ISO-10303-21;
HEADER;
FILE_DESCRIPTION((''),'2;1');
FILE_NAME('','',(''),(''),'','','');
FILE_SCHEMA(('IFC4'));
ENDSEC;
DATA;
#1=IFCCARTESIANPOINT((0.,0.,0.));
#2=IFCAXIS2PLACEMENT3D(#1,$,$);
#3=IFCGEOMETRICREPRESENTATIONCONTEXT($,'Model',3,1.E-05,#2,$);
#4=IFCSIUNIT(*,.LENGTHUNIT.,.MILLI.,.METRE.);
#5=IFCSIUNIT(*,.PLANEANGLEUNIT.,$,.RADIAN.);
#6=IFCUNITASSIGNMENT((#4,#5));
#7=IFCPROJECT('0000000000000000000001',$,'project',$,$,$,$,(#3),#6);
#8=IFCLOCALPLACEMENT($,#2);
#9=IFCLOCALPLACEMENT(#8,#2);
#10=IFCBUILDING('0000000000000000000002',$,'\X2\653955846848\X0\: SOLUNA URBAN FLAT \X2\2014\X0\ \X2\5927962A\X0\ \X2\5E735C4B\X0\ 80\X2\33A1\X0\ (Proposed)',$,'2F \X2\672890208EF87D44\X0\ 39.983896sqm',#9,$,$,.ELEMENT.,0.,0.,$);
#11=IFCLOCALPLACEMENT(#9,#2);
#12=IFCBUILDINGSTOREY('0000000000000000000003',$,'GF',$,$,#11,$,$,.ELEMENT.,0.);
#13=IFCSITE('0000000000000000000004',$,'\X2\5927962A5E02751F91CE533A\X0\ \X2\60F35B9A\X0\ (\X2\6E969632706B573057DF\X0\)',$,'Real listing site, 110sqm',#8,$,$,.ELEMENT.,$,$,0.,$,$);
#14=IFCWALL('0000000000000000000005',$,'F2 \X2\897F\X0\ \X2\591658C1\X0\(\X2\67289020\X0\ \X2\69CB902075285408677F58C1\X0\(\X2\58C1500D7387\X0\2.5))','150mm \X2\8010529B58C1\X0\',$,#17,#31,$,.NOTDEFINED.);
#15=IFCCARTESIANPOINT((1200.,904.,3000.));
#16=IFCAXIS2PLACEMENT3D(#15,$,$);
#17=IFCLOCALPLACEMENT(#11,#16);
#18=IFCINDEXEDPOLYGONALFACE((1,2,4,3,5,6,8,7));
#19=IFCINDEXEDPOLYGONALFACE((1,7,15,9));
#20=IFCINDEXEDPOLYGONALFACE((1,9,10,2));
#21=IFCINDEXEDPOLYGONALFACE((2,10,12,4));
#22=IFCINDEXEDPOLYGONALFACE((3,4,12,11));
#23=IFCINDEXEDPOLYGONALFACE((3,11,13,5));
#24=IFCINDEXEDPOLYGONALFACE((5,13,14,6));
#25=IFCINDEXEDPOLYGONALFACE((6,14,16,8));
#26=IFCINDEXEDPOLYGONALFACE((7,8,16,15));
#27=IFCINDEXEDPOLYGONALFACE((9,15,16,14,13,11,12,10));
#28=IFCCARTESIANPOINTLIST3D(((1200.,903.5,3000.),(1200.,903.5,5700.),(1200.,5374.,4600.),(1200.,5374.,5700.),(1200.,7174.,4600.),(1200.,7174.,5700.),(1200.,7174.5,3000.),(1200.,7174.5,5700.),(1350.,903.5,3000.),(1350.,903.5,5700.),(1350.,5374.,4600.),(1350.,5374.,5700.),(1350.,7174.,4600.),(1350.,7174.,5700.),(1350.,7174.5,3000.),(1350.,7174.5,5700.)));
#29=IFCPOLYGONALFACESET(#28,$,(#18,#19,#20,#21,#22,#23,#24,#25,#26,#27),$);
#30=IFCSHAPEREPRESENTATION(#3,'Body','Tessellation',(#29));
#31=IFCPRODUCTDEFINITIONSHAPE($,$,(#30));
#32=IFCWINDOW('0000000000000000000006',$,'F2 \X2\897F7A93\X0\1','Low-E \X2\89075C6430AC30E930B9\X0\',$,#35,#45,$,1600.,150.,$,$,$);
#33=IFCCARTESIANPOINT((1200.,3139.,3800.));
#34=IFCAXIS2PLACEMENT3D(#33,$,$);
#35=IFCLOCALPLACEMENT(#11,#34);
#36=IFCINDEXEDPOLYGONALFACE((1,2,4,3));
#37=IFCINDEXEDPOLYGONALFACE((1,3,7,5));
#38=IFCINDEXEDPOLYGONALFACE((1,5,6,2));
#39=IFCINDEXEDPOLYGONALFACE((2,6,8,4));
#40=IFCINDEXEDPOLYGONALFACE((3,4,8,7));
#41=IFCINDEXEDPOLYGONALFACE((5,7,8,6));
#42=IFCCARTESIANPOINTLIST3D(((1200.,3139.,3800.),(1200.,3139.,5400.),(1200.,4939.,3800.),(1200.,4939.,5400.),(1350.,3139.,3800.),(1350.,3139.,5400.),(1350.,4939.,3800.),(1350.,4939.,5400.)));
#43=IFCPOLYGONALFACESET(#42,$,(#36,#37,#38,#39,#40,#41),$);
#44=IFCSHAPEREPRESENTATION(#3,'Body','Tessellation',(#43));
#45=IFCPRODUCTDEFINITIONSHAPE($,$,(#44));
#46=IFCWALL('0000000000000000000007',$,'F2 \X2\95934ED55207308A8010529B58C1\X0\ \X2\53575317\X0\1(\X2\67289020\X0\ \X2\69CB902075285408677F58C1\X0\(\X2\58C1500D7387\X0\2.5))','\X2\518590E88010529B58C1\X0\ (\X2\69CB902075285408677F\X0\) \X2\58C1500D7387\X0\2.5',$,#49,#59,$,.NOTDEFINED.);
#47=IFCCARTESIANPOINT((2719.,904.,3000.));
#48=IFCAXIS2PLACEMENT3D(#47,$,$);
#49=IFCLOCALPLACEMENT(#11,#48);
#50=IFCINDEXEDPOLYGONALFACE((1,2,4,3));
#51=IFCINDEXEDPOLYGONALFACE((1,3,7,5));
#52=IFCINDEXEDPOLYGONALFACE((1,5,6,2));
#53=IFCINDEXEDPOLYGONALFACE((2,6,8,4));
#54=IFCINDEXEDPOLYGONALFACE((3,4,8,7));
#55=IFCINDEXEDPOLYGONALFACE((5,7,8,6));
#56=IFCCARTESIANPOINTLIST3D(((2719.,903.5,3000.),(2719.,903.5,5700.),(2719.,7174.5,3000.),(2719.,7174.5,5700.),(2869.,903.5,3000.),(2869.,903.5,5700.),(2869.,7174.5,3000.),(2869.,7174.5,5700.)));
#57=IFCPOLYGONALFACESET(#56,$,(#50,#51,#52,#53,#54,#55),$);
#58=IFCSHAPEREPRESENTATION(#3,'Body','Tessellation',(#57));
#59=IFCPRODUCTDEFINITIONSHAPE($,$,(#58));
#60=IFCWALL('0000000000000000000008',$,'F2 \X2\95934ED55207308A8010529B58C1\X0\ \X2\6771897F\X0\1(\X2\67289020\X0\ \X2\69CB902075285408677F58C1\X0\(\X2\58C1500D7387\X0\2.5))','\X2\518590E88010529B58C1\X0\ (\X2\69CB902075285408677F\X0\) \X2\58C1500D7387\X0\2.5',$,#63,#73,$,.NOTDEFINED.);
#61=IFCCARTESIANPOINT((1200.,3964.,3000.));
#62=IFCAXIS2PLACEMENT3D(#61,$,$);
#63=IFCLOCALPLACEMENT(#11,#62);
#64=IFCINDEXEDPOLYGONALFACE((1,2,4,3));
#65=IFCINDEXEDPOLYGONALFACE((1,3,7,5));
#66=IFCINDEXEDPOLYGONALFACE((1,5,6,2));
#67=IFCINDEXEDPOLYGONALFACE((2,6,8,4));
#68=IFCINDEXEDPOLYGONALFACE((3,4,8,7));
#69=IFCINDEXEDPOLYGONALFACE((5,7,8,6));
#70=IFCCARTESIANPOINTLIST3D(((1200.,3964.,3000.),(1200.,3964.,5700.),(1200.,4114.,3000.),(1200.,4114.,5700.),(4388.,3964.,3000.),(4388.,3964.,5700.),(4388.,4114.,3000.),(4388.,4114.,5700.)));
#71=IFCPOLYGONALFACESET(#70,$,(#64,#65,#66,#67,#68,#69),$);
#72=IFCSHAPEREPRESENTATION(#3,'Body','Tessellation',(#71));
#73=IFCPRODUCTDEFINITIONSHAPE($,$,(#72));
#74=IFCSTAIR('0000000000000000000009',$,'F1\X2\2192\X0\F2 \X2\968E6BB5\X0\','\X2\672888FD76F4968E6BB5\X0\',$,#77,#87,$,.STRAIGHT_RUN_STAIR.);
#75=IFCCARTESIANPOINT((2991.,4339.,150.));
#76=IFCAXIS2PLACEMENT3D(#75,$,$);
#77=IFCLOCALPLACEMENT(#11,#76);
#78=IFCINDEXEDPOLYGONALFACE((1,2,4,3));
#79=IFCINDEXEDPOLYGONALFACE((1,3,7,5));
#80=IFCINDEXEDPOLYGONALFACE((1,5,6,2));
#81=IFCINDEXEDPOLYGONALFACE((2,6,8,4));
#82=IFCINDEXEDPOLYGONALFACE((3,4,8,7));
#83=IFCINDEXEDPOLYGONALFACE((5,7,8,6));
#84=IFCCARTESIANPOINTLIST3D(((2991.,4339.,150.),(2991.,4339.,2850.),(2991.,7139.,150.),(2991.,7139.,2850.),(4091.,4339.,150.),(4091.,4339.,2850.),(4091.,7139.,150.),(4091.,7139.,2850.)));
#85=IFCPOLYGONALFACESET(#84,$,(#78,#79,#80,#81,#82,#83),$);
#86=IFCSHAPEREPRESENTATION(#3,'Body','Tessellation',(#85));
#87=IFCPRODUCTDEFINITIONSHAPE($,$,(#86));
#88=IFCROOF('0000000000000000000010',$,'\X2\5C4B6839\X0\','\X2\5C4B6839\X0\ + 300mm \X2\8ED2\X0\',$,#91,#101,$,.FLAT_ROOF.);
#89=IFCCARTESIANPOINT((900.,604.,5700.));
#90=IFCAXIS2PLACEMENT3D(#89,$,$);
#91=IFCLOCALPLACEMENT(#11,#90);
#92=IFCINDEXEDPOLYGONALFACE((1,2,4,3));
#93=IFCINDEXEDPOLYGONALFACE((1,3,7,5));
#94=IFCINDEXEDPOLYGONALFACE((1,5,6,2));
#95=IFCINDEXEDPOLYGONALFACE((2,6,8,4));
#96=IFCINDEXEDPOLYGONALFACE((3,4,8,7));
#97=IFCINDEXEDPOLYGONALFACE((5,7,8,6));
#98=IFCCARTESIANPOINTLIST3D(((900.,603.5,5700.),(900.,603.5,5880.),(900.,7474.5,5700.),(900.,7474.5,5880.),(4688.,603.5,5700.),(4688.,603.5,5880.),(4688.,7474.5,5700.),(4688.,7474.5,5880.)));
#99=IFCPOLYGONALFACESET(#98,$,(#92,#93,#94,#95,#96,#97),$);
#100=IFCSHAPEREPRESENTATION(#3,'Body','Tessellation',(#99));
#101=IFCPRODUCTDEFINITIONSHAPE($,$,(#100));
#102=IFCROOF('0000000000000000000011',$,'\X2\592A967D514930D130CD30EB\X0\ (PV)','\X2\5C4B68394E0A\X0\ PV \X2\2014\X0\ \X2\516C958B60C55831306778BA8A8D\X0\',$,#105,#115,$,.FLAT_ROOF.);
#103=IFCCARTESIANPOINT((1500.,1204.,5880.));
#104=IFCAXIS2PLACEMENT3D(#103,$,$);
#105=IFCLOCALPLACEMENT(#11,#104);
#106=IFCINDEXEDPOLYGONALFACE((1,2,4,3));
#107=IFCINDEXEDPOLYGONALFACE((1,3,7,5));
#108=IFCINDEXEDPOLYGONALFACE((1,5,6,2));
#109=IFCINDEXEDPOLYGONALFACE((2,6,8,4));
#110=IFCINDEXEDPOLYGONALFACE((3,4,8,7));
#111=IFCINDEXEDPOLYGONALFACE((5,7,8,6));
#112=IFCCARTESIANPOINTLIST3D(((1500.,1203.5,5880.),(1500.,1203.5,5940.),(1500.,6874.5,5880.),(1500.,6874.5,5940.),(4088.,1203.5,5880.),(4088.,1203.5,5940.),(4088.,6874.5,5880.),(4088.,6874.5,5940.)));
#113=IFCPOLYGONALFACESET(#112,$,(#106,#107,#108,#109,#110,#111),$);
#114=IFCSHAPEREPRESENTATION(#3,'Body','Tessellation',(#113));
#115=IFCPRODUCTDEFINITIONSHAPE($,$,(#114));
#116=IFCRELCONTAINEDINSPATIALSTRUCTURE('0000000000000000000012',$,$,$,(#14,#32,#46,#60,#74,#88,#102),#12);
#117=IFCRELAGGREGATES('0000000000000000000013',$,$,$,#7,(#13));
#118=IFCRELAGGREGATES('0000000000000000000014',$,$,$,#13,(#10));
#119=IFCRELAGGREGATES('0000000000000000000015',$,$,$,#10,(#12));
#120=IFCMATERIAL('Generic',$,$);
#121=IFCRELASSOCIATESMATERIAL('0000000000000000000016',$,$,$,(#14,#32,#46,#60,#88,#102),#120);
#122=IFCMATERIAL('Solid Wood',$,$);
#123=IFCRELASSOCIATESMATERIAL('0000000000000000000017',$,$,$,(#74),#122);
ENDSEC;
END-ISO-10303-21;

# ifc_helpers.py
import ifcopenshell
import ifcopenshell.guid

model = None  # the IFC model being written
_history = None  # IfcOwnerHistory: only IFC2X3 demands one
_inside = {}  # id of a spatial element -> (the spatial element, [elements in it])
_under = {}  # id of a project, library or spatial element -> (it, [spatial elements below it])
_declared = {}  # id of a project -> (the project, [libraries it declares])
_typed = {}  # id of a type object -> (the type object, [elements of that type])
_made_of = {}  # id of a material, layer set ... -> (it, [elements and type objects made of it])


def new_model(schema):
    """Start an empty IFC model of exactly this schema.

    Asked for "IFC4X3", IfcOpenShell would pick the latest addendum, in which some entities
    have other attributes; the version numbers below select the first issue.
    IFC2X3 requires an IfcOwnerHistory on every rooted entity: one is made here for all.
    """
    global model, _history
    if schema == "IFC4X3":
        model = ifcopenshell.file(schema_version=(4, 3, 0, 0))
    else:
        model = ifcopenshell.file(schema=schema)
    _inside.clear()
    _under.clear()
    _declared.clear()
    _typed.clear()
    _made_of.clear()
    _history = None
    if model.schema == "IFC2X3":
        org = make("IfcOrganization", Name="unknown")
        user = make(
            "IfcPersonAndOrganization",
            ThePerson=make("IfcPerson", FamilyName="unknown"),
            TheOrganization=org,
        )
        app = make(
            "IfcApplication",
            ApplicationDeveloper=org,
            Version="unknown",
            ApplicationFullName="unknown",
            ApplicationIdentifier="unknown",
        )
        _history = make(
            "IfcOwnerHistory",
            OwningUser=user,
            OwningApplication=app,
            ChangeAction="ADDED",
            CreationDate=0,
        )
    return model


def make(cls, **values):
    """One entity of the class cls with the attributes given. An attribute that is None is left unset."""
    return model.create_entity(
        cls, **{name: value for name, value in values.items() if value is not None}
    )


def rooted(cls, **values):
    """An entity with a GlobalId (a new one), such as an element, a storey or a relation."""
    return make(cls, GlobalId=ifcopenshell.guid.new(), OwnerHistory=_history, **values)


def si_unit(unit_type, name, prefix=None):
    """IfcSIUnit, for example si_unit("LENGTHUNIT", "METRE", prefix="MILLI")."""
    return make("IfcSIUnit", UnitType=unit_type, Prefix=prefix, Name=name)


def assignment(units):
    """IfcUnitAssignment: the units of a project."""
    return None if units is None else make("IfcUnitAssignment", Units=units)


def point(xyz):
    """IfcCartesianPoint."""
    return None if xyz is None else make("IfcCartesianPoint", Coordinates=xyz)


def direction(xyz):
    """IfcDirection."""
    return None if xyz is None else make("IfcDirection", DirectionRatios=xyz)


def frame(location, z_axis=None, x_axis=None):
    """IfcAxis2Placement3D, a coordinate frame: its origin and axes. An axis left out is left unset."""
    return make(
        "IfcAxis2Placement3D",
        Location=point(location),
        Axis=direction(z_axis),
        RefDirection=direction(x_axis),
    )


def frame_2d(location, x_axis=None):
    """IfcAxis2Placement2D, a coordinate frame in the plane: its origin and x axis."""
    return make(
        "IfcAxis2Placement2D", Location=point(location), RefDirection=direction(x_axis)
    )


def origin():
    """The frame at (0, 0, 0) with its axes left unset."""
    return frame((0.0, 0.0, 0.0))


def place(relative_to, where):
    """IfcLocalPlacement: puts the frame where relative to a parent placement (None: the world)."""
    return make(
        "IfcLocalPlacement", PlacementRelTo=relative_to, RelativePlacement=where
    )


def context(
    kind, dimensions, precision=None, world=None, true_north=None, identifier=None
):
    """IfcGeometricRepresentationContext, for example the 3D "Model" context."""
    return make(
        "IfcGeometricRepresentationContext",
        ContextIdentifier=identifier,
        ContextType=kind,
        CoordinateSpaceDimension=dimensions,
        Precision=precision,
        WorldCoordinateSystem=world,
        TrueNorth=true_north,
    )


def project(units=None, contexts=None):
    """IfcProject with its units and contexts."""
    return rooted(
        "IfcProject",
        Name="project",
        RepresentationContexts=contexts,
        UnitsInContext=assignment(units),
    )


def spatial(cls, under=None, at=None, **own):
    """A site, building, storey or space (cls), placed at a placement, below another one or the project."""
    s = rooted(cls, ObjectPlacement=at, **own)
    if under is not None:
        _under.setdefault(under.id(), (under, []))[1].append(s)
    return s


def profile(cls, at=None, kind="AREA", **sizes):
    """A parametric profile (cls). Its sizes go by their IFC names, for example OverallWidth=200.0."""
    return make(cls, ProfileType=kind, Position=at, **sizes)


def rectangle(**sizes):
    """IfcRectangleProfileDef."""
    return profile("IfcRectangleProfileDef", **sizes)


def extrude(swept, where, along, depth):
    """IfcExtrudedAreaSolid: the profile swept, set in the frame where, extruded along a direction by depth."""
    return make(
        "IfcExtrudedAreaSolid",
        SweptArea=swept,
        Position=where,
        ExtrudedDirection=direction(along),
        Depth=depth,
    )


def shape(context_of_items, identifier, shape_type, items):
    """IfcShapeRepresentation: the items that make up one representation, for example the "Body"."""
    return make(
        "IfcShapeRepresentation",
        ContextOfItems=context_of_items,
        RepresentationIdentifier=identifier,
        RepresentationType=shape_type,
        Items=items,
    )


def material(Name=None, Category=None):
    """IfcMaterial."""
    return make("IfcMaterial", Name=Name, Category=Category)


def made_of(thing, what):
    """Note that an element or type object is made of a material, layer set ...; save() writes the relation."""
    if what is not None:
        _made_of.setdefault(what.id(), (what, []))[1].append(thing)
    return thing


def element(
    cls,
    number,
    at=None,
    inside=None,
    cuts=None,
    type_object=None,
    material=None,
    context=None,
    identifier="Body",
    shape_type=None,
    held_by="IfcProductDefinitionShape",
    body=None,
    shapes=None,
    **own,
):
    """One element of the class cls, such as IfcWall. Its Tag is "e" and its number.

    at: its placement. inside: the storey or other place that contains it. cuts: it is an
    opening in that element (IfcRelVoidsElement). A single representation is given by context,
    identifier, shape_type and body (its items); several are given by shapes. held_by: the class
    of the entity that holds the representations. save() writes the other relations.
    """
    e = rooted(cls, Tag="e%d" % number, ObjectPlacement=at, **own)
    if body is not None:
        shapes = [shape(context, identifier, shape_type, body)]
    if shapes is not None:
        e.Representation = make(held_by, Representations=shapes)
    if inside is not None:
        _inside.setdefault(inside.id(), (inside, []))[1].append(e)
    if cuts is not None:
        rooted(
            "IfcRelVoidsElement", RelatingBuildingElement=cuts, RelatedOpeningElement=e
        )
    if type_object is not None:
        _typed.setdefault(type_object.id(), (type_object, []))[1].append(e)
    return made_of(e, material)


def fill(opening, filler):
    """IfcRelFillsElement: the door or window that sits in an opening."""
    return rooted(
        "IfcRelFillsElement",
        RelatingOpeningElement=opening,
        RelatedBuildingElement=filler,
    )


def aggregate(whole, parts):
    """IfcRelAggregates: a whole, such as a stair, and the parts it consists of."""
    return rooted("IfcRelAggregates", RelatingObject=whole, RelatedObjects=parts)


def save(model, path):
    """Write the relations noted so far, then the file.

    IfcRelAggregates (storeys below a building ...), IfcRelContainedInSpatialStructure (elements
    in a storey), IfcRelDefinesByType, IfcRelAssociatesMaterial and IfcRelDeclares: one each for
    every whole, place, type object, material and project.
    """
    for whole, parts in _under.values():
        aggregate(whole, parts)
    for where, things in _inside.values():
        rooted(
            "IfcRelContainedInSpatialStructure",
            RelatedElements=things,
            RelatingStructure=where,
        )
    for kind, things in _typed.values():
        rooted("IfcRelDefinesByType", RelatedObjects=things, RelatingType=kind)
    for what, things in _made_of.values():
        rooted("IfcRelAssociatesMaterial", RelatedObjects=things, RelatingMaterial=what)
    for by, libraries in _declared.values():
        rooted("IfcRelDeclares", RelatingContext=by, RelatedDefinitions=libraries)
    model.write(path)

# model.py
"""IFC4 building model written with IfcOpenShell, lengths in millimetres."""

from ifc_helpers import new_model, si_unit, frame, frame_2d, origin, place, context, project, spatial, rectangle, extrude, material, element, fill, save


model = new_model("IFC4")

# Units and contexts
model_context = context("Model", 3, precision=1e-05, world=origin())
ifc_project = project(units=[si_unit("LENGTHUNIT", "METRE", prefix="MILLI"), si_unit("PLANEANGLEUNIT", "RADIAN")], contexts=[model_context])

# Site, building, storey
site_placement = place(None, origin())
site = spatial("IfcSite", under=ifc_project, at=site_placement, Name="大阪市生野区 想定 (準防火地域)", ObjectType="Real listing site, 110sqm", CompositionType="ELEMENT", RefElevation=0.0)
building_placement = place(site_placement, origin())
building = spatial("IfcBuilding", under=site, at=building_placement, Name="改善案: SOLUNA URBAN FLAT — 大阪 平屋 80㎡ (Proposed)", ObjectType="2F 木造軸組 39.983896sqm", CompositionType="ELEMENT", ElevationOfRefHeight=0.0, ElevationOfTerrain=0.0)
storey_placement = place(building_placement, origin())
storey = spatial("IfcBuildingStorey", under=building, at=storey_placement, Name="GF", CompositionType="ELEMENT", Elevation=0.0)

# Shared definitions
ifc_material_1 = material(Name="Generic")

# Shared definitions
ifc_material_2 = material(Name="Solid Wood")

# Wall, opening, window
wall_1_placement = place(storey_placement, frame((1200.0, 904.0, 3000.0)))
wall_1 = element("IfcWall", 1, at=wall_1_placement, inside=storey, material=ifc_material_1, Name="F2 西 外壁(木造 構造用合板壁(壁倍率2.5))", Description="150mm 耐力壁", PredefinedType="NOTDEFINED", context=model_context, shape_type="SweptSolid", body=[
    extrude(rectangle(XDim=150.0, YDim=6271.0, at=frame_2d((75.0, 3135.0))), frame((1200.0, 904.0, 3000.0)), (0.0, 0.0, 1.0), 2700.0),
])
opening_1_placement = place(storey_placement, frame((1200.0, 3139.0, 3800.0)))
opening_1 = element("IfcOpeningElement", 2, at=opening_1_placement, cuts=wall_1, PredefinedType="NOTDEFINED", context=model_context, shape_type="SweptSolid", body=[
    extrude(rectangle(XDim=150.0, YDim=1800.0, at=frame_2d((75.0, 900.0))), frame((1200.0, 3139.0, 3800.0)), (0.0, 0.0, 1.0), 1600.0),
])
window_1_placement = place(storey_placement, frame((1200.0, 3139.0, 3800.0)))
window_1 = element("IfcWindow", 3, at=window_1_placement, inside=storey, material=ifc_material_1, Name="F2 西窓1", Description="Low-E 複層ガラス", OverallHeight=1600.0, OverallWidth=150.0, context=model_context, shape_type="SweptSolid", body=[
    extrude(rectangle(XDim=150.0, YDim=1800.0, at=frame_2d((75.0, 900.0))), frame((1200.0, 3139.0, 3800.0)), (0.0, 0.0, 1.0), 1600.0),
])
fill(opening_1, window_1)

# Walls
wall_2_placement = place(storey_placement, frame((2719.0, 904.0, 3000.0)))
element("IfcWall", 4, at=wall_2_placement, inside=storey, material=ifc_material_1, Name="F2 間仕切り耐力壁 南北1(木造 構造用合板壁(壁倍率2.5))", Description="内部耐力壁 (構造用合板) 壁倍率2.5", PredefinedType="NOTDEFINED", context=model_context, shape_type="SweptSolid", body=[
    extrude(rectangle(XDim=150.0, YDim=6271.0, at=frame_2d((75.0, 3135.0))), frame((2719.0, 904.0, 3000.0)), (0.0, 0.0, 1.0), 2700.0),
])
wall_3_placement = place(storey_placement, frame((1200.0, 3964.0, 3000.0)))
element("IfcWall", 5, at=wall_3_placement, inside=storey, material=ifc_material_1, Name="F2 間仕切り耐力壁 東西1(木造 構造用合板壁(壁倍率2.5))", Description="内部耐力壁 (構造用合板) 壁倍率2.5", PredefinedType="NOTDEFINED", context=model_context, shape_type="SweptSolid", body=[
    extrude(rectangle(XDim=3188.0, YDim=150.0, at=frame_2d((1594.0, 75.0))), frame((1200.0, 3964.0, 3000.0)), (0.0, 0.0, 1.0), 2700.0),
])

# Stair
stair_placement = place(storey_placement, frame((2991.0, 4339.0, 150.0)))
element("IfcStair", 6, at=stair_placement, inside=storey, material=ifc_material_2, Name="F1→F2 階段", Description="木製直階段", PredefinedType="STRAIGHT_RUN_STAIR", context=model_context, shape_type="SweptSolid", body=[
    extrude(rectangle(XDim=1100.0, YDim=2800.0, at=frame_2d((550.0, 1400.0))), frame((2991.0, 4339.0, 150.0)), (0.0, 0.0, 1.0), 2700.0),
])

# Roofs
roof_1_placement = place(storey_placement, frame((900.0, 604.0, 5700.0)))
element("IfcRoof", 7, at=roof_1_placement, inside=storey, material=ifc_material_1, Name="屋根", Description="屋根 + 300mm 軒", PredefinedType="FLAT_ROOF", context=model_context, shape_type="SweptSolid", body=[
    extrude(rectangle(XDim=3788.0, YDim=6871.0, at=frame_2d((1894.0, 3435.0))), frame((900.0, 604.0, 5700.0)), (0.0, 0.0, 1.0), 180.0),
])
roof_2_placement = place(storey_placement, frame((1500.0, 1204.0, 5880.0)))
element("IfcRoof", 8, at=roof_2_placement, inside=storey, material=ifc_material_1, Name="太陽光パネル (PV)", Description="屋根上 PV — 公開情報で確認", PredefinedType="FLAT_ROOF", context=model_context, shape_type="SweptSolid", body=[
    extrude(rectangle(XDim=2588.0, YDim=5671.0, at=frame_2d((1294.0, 2835.0))), frame((1500.0, 1204.0, 5880.0)), (0.0, 0.0, 1.0), 60.0),
])

save(model, "model.ifc")
